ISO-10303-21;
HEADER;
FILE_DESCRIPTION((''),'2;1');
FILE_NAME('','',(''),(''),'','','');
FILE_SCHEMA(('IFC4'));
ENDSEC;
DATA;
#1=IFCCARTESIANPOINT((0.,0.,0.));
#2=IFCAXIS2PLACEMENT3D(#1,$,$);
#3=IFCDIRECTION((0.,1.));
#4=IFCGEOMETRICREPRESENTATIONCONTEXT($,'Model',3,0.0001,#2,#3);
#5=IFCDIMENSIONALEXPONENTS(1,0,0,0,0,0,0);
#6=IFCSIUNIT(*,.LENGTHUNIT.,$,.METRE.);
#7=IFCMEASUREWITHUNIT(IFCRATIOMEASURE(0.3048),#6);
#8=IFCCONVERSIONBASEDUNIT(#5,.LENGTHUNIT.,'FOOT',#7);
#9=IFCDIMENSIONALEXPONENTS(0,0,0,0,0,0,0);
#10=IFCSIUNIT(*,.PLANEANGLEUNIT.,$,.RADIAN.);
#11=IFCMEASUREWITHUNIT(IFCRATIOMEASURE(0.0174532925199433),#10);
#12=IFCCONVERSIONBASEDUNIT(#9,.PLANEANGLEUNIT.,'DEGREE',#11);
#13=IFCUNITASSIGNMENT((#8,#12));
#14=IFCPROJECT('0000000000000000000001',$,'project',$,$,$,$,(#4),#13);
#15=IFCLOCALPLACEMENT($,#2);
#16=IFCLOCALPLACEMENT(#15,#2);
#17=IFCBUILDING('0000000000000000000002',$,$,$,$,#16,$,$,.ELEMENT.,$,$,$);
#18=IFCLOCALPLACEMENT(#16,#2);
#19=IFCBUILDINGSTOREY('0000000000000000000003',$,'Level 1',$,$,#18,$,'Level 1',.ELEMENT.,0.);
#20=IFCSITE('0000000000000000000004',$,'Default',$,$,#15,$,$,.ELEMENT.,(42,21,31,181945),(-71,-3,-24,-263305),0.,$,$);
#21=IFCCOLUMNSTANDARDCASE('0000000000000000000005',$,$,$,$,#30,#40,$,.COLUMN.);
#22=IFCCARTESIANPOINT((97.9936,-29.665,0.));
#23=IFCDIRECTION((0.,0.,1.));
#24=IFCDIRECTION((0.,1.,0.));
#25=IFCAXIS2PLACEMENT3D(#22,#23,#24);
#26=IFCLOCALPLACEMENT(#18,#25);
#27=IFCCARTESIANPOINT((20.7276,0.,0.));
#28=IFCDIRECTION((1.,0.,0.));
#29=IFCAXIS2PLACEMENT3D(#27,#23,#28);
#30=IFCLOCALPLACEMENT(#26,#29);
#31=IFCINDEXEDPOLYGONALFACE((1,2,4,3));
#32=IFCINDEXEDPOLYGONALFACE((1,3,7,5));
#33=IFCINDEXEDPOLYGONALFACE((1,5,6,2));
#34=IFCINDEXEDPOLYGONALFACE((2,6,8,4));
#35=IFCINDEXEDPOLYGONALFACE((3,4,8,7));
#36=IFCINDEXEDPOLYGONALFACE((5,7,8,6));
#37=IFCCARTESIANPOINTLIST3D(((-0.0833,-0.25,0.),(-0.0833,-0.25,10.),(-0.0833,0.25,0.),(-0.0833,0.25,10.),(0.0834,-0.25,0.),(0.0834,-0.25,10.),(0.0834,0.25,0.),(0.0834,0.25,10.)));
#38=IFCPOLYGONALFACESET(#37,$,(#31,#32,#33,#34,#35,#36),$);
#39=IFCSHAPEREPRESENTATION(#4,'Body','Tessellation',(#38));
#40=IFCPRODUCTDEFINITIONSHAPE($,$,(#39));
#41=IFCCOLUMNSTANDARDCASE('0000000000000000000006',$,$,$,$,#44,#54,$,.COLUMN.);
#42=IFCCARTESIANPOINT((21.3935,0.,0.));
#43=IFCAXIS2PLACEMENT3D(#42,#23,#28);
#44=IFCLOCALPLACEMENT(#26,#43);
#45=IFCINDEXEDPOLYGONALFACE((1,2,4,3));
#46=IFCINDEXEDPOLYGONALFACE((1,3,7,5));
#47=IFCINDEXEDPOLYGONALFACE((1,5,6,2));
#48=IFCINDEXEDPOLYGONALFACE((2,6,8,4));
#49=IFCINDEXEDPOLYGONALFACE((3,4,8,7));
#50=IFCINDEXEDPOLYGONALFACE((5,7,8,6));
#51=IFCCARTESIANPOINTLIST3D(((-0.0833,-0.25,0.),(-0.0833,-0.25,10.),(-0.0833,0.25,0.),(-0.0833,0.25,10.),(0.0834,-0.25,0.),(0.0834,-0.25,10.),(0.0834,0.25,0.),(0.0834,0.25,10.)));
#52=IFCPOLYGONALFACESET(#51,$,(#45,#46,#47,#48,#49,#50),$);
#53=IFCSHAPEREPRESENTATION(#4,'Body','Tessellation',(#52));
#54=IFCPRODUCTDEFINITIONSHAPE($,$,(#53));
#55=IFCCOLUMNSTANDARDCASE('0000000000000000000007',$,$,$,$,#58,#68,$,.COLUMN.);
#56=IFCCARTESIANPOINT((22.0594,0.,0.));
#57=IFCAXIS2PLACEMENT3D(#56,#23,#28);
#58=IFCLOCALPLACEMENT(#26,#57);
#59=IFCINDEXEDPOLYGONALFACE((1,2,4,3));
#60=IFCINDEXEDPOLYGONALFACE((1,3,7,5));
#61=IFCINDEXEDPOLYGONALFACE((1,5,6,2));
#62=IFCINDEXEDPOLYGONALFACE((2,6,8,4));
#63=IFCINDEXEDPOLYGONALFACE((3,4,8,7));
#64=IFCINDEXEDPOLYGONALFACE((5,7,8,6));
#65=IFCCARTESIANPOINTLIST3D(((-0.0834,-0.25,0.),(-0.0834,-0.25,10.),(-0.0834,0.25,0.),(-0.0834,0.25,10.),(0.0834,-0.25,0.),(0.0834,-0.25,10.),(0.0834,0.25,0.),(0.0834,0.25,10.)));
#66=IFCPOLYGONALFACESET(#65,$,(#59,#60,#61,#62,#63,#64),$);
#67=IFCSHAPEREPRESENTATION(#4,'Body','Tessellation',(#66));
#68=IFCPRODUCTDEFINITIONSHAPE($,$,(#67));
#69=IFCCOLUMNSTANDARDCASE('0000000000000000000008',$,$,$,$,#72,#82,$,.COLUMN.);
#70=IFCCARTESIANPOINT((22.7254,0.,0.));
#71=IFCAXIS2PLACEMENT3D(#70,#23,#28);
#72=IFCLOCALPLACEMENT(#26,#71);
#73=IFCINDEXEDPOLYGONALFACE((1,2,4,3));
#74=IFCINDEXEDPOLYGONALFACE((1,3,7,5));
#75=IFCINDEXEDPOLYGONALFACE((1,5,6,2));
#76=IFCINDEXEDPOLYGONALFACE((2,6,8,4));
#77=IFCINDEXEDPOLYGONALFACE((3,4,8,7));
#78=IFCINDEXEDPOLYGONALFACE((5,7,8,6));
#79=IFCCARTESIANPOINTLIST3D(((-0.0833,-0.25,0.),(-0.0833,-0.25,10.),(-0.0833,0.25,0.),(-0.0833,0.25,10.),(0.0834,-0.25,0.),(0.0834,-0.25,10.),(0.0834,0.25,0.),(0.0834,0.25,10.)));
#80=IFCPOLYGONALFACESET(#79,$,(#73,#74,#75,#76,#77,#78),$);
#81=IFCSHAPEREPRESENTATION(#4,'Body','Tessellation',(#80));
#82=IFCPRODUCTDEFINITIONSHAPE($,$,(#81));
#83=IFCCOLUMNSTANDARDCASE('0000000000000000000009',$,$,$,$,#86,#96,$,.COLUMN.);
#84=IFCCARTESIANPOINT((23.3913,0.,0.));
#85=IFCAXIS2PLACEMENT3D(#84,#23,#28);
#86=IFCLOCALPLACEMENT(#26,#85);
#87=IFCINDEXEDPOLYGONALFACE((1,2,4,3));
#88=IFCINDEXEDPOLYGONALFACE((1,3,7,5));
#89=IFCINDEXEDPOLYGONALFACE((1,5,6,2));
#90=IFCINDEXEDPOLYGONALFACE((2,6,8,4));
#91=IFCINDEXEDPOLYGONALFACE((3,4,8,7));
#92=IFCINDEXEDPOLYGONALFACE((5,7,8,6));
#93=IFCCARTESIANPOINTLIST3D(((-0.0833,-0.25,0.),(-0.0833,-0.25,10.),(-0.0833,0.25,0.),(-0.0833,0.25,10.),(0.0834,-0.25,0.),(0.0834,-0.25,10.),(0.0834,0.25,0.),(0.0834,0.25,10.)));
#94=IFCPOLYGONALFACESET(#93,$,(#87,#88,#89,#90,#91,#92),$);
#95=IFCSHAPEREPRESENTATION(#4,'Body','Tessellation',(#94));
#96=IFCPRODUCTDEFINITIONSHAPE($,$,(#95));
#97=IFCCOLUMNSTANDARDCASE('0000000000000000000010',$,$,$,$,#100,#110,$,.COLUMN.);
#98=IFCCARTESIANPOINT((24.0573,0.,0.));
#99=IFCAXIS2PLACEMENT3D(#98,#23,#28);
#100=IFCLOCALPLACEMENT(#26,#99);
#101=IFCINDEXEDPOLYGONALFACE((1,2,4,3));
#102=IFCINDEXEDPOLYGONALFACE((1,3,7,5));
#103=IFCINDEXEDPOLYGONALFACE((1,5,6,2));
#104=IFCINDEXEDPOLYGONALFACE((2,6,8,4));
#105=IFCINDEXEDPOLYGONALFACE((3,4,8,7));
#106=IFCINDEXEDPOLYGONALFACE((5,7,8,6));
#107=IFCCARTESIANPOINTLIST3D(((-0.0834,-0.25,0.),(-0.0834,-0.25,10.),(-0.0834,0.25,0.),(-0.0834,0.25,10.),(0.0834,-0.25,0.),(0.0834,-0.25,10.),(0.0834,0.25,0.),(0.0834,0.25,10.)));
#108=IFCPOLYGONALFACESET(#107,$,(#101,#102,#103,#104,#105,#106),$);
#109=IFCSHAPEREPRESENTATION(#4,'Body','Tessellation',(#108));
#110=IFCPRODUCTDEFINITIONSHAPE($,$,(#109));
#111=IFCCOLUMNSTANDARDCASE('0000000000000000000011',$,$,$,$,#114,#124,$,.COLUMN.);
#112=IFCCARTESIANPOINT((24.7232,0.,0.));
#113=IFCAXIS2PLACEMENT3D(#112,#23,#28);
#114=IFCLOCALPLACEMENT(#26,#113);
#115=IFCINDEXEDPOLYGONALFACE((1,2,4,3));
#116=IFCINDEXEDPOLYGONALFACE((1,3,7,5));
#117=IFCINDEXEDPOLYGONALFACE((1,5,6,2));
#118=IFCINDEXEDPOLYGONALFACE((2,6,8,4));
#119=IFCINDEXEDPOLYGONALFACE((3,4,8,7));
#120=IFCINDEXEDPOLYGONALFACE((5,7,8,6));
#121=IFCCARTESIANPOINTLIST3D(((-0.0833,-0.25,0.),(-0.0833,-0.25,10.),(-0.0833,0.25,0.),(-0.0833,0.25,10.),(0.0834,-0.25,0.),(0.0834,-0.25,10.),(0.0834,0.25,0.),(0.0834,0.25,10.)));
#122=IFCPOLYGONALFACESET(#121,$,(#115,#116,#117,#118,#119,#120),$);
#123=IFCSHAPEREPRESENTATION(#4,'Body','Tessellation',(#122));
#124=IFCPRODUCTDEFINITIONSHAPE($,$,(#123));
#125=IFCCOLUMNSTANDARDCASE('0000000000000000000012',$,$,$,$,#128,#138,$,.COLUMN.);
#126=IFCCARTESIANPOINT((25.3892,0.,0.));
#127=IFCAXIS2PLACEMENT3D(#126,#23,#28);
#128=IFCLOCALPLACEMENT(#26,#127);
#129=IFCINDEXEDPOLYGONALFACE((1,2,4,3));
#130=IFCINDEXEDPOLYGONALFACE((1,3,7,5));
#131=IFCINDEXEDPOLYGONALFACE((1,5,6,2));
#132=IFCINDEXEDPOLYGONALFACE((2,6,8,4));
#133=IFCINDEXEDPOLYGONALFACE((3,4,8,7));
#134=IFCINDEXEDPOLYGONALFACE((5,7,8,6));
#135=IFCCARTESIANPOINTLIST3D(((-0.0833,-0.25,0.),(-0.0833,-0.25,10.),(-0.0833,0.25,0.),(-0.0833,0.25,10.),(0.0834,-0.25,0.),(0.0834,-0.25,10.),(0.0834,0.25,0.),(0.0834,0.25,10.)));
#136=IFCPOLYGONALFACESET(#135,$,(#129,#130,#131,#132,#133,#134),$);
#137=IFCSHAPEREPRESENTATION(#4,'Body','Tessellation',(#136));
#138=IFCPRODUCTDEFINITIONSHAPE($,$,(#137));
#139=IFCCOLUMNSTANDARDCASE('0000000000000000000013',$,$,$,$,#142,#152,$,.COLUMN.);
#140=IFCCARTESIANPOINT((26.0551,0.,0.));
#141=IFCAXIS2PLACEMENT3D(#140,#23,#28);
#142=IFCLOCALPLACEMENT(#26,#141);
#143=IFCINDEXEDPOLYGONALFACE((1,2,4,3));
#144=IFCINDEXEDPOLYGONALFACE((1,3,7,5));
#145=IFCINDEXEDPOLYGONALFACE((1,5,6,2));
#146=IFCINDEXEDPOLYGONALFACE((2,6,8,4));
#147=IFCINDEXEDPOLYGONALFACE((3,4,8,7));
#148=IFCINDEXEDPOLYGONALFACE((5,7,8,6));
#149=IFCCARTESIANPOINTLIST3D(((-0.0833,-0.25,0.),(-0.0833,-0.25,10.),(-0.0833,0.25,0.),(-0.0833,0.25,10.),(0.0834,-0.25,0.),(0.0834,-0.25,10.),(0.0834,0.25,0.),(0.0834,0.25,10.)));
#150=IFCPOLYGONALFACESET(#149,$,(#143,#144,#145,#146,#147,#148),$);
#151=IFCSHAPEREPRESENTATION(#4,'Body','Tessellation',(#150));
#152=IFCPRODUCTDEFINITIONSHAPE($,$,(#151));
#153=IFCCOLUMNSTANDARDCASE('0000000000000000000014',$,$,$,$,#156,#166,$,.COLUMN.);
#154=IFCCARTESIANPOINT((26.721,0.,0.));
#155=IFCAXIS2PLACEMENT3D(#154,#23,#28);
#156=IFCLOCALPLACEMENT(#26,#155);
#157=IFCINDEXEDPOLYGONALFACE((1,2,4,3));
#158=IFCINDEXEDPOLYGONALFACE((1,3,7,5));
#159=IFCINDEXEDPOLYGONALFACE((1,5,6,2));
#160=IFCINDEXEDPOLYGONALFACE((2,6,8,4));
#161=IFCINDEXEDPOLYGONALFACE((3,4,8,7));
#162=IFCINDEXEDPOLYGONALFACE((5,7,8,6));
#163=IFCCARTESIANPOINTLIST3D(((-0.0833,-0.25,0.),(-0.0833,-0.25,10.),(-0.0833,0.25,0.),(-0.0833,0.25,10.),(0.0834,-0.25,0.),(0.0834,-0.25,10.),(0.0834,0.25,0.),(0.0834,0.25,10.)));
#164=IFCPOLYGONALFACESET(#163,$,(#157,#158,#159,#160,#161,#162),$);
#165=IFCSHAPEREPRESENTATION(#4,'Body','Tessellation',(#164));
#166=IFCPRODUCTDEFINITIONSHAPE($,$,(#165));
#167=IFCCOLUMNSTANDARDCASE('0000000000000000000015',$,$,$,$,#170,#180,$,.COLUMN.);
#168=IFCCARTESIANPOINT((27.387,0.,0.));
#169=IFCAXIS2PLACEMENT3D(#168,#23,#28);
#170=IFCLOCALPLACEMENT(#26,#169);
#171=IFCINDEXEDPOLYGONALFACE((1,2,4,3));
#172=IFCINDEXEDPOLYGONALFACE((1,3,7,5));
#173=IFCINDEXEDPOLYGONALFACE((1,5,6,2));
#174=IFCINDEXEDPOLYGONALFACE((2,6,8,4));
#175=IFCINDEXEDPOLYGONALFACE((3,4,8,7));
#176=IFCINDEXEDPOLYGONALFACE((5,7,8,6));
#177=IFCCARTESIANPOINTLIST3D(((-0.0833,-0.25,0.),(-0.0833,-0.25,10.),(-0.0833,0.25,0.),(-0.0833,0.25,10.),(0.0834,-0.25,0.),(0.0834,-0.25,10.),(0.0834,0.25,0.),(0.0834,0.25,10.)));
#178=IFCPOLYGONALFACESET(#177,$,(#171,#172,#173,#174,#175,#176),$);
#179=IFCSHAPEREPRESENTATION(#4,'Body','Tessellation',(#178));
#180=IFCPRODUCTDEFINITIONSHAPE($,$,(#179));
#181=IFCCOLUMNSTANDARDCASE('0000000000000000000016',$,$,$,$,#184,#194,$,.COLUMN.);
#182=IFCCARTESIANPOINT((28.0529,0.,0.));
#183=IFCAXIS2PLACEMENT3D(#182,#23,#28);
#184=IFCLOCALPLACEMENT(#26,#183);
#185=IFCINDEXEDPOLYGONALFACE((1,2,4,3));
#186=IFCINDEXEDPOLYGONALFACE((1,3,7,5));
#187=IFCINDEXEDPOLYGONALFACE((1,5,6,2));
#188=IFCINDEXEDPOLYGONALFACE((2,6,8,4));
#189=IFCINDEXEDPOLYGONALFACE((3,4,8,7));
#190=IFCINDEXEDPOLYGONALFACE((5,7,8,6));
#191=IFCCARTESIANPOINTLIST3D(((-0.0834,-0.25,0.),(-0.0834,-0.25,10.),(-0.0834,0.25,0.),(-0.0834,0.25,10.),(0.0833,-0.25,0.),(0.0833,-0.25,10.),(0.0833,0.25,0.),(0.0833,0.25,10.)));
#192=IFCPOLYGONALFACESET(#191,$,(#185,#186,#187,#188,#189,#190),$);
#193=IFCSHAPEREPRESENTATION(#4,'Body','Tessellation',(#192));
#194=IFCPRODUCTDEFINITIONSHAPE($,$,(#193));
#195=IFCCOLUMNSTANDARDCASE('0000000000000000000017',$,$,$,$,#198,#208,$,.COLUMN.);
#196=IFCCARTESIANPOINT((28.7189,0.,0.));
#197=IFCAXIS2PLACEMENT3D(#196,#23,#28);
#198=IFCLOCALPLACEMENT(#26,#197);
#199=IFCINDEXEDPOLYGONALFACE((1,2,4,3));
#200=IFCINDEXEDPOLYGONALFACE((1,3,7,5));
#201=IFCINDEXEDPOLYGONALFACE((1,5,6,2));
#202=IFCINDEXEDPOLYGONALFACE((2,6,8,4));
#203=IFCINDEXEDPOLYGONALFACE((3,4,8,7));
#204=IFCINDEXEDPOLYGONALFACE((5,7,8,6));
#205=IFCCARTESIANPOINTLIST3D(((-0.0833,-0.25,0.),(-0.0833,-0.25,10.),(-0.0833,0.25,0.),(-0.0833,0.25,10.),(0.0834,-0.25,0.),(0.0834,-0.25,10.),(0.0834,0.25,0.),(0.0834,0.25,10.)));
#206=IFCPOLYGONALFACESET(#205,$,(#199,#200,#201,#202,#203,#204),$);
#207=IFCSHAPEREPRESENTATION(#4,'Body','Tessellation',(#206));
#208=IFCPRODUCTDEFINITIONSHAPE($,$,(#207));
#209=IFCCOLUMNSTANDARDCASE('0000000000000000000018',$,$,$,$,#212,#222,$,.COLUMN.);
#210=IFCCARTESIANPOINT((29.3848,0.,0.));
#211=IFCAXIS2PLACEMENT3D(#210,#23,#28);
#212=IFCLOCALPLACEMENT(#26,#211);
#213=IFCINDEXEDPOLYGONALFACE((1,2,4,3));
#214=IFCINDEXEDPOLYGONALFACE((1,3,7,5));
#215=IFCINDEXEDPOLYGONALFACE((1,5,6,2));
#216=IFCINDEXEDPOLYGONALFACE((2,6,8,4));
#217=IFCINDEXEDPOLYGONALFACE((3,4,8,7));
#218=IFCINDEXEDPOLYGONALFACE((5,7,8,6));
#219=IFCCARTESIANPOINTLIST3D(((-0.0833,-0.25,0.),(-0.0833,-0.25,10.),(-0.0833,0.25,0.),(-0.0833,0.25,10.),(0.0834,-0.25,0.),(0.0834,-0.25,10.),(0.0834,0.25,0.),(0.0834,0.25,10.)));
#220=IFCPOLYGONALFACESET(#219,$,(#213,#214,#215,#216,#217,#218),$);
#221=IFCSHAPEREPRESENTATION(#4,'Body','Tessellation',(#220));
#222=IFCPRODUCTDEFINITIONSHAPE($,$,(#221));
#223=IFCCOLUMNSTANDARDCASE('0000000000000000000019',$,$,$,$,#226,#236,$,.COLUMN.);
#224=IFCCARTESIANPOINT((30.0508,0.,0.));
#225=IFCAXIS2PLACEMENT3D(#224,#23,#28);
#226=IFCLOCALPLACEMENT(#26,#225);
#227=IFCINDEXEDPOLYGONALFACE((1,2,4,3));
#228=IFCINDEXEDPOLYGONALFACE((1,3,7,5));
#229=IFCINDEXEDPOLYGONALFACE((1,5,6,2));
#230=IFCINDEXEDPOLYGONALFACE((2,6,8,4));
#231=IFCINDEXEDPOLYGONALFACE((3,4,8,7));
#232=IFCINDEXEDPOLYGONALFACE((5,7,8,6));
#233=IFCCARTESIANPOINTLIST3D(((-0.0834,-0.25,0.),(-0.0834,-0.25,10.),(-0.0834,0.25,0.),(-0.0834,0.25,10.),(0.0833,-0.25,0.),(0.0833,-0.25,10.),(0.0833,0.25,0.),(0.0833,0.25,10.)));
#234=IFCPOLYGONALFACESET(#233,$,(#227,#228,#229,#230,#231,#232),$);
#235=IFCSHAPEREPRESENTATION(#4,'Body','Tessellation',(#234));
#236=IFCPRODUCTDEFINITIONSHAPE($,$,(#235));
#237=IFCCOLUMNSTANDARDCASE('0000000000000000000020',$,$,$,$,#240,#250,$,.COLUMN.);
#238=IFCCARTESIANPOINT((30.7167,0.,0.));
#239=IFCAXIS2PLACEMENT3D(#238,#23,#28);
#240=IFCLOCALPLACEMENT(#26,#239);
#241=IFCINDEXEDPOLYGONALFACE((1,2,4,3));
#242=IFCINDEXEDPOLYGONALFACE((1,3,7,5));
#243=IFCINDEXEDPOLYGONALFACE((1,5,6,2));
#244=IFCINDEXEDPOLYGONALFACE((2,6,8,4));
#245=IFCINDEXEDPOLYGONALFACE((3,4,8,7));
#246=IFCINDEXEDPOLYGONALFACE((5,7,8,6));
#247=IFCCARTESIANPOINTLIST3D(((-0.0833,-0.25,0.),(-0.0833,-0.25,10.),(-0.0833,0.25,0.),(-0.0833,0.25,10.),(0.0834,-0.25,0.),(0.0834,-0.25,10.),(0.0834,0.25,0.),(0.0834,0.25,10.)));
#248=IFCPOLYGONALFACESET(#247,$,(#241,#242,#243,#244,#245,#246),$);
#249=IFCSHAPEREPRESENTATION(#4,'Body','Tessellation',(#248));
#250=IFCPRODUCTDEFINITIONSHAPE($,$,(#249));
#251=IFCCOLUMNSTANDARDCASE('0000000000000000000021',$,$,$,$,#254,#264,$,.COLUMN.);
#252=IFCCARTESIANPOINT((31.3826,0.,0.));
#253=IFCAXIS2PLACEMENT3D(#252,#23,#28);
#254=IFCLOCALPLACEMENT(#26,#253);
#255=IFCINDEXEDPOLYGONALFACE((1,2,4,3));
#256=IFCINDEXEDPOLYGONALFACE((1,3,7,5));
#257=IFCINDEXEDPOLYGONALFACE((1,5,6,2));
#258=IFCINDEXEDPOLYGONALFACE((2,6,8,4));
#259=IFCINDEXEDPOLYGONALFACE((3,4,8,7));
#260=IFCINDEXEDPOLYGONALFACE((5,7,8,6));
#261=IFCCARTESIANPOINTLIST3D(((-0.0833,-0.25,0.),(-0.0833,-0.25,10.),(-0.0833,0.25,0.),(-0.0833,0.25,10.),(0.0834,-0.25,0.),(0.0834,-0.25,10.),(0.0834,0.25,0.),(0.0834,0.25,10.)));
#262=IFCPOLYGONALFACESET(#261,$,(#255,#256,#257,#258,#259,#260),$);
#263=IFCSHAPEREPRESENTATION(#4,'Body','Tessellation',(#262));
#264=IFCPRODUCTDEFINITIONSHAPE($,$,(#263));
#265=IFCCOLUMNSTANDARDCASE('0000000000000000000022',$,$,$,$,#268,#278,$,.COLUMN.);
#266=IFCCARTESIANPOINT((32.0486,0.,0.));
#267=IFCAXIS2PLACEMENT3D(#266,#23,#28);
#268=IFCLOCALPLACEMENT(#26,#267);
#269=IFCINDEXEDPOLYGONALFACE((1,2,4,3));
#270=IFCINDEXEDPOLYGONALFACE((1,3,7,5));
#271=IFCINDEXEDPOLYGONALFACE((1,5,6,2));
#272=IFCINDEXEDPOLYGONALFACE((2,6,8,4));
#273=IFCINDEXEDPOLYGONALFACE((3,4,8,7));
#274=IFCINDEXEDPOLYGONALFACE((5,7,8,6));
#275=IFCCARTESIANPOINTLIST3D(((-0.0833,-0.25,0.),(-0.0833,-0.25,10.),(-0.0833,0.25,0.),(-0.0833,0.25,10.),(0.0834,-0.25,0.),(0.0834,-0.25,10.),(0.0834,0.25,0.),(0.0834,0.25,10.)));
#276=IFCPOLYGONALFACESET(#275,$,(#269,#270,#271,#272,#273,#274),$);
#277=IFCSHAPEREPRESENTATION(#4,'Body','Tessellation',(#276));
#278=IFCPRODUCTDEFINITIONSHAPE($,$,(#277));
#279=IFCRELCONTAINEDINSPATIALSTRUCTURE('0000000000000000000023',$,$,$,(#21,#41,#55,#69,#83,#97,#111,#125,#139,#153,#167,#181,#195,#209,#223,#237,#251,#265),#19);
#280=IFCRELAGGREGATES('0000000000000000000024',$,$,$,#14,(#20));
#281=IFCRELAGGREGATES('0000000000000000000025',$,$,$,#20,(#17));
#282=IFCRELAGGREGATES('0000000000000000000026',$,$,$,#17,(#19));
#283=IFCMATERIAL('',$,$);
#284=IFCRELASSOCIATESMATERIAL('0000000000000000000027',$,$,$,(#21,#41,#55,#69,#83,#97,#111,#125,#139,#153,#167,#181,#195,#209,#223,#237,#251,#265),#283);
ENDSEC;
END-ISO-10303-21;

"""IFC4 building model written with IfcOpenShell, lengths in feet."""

from ifc_helpers import new_model, entity, si_unit, converted_unit, direction, frame, origin, place, context, project, spatial, rectangle, extrude, material, element, save


model = new_model("IFC4")

# Units and contexts
model_context = context("Model", 3, precision=0.0001, world=origin(), true_north=direction((0.0, 1.0)))
ifc_project = project(units=[converted_unit("LENGTHUNIT", "FOOT", entity("IfcRatioMeasure", 0.3048), si_unit("LENGTHUNIT", "METRE"), dimensions=[1, 0, 0, 0, 0, 0, 0]), converted_unit("PLANEANGLEUNIT", "DEGREE", entity("IfcRatioMeasure", 0.0174532925199433), si_unit("PLANEANGLEUNIT", "RADIAN"), dimensions=[0, 0, 0, 0, 0, 0, 0])], contexts=[model_context])

# Site, building, storey
site_placement = place(None, origin())
site = spatial("IfcSite", under=ifc_project, at=site_placement, Name="Default", CompositionType="ELEMENT", RefLatitude=(42, 21, 31, 181945), RefLongitude=(-71, -3, -24, -263305), RefElevation=0.0)
building_placement = place(site_placement, origin())
building = spatial("IfcBuilding", under=site, at=building_placement, CompositionType="ELEMENT")
storey_placement = place(building_placement, origin())
storey = spatial("IfcBuildingStorey", under=building, at=storey_placement, Name="Level 1", LongName="Level 1", CompositionType="ELEMENT", Elevation=0.0)

# Columns
ifc_material = material(Name="")
placement = place(storey_placement, frame((97.9936, -29.665, 0.0), z_axis=(0.0, 0.0, 1.0), x_axis=(0.0, 1.0, 0.0)))
for number, where, z_axis, x_axis in (
    (1, (20.7276, 0.0, 0.0), (0.0, 0.0, 1.0), (1.0, 0.0, 0.0)),
    (2, (21.3935, 0.0, 0.0), (0.0, 0.0, 1.0), (1.0, 0.0, 0.0)),
    (3, (22.0594, 0.0, 0.0), (0.0, 0.0, 1.0), (1.0, 0.0, 0.0)),
    (4, (22.7254, 0.0, 0.0), (0.0, 0.0, 1.0), (1.0, 0.0, 0.0)),
    (5, (23.3913, 0.0, 0.0), (0.0, 0.0, 1.0), (1.0, 0.0, 0.0)),
    (6, (24.0573, 0.0, 0.0), (0.0, 0.0, 1.0), (1.0, 0.0, 0.0)),
    (7, (24.7232, 0.0, 0.0), (0.0, 0.0, 1.0), (1.0, 0.0, 0.0)),
    (8, (25.3892, 0.0, 0.0), (0.0, 0.0, 1.0), (1.0, 0.0, 0.0)),
    (9, (26.0551, 0.0, 0.0), (0.0, 0.0, 1.0), (1.0, 0.0, 0.0)),
    (10, (26.721, 0.0, 0.0), (0.0, 0.0, 1.0), (1.0, 0.0, 0.0)),
    (11, (27.387, 0.0, 0.0), (0.0, 0.0, 1.0), (1.0, 0.0, 0.0)),
    (12, (28.0529, 0.0, 0.0), (0.0, 0.0, 1.0), (1.0, 0.0, 0.0)),
    (13, (28.7189, 0.0, 0.0), (0.0, 0.0, 1.0), (1.0, 0.0, 0.0)),
    (14, (29.3848, 0.0, 0.0), (0.0, 0.0, 1.0), (1.0, 0.0, 0.0)),
    (15, (30.0508, 0.0, 0.0), (0.0, 0.0, 1.0), (1.0, 0.0, 0.0)),
    (16, (30.7167, 0.0, 0.0), (0.0, 0.0, 1.0), (1.0, 0.0, 0.0)),
    (17, (31.3826, 0.0, 0.0), (0.0, 0.0, 1.0), (1.0, 0.0, 0.0)),
    (18, (32.0486, 0.0, 0.0), (0.0, 0.0, 1.0), (1.0, 0.0, 0.0)),
):
    element("IfcColumnStandardCase", number, at=place(placement, frame(where, z_axis=z_axis, x_axis=x_axis)), inside=storey, material=ifc_material, PredefinedType="COLUMN", context=model_context, shape_type="SweptSolid", body=[
        extrude(rectangle(XDim=0.1667, YDim=0.5), origin(), (0.0, 0.0, 1.0), 10.0),
    ])

save(model, "model.ifc")
